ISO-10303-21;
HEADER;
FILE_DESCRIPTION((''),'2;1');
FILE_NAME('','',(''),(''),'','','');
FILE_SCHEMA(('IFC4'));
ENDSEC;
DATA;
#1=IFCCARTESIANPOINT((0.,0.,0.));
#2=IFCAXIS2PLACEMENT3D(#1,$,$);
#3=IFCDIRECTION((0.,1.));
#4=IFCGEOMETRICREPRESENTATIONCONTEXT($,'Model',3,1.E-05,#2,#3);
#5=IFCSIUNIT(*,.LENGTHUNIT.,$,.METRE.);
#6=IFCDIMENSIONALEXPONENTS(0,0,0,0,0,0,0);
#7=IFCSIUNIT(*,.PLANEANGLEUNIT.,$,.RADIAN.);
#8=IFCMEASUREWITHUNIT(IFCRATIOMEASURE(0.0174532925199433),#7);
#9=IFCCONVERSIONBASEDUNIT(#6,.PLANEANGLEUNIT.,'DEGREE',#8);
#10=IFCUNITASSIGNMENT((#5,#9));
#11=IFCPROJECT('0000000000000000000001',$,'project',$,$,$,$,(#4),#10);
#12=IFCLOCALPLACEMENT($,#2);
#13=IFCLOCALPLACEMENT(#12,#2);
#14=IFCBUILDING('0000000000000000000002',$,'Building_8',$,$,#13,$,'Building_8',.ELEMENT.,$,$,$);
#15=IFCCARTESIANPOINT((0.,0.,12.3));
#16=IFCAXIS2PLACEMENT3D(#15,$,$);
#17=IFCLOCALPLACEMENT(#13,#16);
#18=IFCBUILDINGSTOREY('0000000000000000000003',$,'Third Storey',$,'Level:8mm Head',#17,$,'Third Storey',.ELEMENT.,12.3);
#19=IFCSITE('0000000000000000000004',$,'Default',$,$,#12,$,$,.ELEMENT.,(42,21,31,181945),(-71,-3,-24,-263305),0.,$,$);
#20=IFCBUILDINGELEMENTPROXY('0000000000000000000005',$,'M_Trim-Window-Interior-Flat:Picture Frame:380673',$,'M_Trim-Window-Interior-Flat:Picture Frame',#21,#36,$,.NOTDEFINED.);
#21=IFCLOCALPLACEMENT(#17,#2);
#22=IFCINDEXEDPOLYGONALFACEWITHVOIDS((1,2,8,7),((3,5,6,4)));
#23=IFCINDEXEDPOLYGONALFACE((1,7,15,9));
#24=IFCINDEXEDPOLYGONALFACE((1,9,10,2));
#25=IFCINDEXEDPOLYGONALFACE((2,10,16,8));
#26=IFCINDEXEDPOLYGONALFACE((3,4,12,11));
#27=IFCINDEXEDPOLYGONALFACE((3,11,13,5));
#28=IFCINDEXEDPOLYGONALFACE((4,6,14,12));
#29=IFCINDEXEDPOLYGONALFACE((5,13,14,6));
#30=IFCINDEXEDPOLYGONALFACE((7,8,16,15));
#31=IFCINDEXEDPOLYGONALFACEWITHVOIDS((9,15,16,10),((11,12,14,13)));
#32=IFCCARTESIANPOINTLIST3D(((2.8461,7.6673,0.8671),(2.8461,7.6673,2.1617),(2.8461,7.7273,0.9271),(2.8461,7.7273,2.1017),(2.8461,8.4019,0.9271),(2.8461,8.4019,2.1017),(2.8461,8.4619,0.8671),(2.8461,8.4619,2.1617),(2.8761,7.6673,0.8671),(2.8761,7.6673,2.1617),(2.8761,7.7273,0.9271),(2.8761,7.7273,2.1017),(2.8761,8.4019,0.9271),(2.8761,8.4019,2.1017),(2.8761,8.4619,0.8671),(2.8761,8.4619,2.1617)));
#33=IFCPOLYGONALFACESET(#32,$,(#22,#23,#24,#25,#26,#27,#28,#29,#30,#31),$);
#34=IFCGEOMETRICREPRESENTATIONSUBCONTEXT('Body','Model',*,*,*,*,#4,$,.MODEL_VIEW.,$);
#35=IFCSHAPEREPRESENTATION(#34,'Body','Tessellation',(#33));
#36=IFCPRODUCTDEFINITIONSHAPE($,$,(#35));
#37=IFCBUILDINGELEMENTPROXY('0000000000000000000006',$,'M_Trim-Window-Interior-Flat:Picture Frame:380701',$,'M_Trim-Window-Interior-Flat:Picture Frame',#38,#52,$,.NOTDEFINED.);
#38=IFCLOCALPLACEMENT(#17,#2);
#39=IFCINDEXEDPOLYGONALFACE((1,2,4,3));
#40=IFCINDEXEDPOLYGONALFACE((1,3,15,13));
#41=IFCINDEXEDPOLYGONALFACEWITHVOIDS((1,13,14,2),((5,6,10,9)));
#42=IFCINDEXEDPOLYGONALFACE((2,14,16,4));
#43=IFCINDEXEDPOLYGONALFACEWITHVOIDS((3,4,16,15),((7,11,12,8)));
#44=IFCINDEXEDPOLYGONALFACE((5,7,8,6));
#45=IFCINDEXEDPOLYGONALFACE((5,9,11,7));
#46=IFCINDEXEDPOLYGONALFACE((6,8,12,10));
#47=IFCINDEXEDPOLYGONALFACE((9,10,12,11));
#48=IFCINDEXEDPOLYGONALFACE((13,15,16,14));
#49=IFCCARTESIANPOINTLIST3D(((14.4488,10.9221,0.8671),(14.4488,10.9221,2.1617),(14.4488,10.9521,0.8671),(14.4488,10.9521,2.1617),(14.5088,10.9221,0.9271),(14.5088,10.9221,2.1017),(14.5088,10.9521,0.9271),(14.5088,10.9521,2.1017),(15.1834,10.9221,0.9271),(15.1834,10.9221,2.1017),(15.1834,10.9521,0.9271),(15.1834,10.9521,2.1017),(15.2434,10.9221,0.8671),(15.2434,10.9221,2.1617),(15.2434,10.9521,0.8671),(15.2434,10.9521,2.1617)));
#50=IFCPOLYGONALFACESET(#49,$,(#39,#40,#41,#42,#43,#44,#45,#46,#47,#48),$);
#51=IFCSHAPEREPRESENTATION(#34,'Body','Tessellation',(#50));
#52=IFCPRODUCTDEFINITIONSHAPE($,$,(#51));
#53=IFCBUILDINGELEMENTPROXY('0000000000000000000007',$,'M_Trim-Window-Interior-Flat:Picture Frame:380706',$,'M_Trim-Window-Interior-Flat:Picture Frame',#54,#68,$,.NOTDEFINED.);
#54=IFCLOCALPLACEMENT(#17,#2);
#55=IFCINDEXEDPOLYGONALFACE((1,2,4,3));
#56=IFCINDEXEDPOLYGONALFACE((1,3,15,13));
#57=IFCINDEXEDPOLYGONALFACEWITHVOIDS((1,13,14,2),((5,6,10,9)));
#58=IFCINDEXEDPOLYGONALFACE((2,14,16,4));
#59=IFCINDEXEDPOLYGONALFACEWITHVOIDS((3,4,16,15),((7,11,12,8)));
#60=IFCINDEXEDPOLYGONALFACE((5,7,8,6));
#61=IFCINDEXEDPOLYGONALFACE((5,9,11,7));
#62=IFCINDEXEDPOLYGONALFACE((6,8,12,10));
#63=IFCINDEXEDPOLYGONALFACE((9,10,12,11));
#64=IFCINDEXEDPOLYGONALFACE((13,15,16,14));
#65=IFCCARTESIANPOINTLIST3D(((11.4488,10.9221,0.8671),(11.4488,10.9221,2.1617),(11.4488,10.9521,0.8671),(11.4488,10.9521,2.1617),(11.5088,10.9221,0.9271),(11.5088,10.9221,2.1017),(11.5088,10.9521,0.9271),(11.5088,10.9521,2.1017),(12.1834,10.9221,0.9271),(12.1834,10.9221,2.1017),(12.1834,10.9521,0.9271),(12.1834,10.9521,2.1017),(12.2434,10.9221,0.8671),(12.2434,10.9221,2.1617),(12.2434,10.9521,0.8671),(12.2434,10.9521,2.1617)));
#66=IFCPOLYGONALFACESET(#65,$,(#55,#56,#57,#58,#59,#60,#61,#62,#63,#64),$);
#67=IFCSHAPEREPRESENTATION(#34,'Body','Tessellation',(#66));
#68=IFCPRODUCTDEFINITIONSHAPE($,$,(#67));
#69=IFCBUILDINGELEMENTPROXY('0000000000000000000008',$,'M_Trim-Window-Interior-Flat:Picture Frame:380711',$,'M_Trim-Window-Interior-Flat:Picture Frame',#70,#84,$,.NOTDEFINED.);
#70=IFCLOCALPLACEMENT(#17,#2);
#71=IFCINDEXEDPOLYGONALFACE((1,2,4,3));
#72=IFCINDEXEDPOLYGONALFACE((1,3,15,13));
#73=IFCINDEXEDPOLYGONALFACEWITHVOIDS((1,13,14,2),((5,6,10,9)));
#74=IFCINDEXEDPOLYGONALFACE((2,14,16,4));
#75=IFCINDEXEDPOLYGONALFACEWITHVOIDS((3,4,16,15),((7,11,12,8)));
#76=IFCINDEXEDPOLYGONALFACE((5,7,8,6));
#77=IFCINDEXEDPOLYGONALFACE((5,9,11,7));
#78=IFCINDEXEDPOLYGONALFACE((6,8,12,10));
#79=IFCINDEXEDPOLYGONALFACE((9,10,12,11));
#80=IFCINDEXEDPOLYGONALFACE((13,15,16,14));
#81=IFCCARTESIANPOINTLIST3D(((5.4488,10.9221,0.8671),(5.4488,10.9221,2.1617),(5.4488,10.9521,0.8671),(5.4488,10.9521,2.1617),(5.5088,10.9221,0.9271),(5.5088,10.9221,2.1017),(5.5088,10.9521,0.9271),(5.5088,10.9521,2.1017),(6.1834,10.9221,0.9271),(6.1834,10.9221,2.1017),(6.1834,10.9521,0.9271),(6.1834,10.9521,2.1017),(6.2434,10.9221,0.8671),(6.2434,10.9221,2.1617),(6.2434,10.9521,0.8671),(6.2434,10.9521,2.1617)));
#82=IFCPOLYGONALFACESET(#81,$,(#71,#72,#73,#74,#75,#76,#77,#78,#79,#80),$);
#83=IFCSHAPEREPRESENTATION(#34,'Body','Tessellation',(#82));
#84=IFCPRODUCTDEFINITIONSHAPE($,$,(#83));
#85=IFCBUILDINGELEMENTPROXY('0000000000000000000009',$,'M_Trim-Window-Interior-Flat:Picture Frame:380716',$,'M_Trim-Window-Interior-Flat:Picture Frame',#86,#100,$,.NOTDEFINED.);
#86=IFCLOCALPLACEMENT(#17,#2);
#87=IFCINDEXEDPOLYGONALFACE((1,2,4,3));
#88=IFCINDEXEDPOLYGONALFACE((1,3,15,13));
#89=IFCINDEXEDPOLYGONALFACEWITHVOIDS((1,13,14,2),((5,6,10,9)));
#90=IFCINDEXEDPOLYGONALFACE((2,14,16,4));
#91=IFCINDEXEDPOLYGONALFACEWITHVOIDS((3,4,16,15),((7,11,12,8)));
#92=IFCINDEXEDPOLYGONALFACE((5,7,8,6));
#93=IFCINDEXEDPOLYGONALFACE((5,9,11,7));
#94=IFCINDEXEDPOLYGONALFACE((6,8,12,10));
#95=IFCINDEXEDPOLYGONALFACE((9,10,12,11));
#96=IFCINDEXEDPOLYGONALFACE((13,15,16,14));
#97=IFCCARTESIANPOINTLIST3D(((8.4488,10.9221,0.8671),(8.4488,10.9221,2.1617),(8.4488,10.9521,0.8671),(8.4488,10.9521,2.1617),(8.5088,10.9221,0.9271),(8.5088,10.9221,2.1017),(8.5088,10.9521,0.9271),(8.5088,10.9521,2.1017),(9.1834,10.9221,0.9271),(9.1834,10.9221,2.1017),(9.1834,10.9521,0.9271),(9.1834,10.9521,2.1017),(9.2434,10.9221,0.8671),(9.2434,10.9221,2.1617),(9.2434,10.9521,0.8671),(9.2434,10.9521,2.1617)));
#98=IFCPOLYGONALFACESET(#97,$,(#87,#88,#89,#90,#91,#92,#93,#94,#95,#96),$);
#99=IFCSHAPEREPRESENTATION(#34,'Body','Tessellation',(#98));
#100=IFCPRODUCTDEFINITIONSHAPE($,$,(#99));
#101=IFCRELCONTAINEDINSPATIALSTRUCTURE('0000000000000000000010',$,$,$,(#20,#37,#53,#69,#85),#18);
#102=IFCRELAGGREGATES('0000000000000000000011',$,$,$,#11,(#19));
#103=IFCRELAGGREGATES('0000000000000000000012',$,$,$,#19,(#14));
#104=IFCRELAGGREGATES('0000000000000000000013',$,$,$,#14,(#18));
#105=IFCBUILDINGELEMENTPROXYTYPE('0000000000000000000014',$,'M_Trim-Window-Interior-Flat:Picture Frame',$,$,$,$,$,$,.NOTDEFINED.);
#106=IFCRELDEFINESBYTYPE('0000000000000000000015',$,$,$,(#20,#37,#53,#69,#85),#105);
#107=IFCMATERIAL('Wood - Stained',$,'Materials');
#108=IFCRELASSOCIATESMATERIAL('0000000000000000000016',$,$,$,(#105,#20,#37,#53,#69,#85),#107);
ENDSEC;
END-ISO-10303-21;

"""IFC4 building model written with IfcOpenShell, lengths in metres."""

from ifc_helpers import new_model, entity, si_unit, converted_unit, direction, frame, origin, place, context, subcontext, project, spatial, indexed_curve, outline, extrude, source, transform, mapped, material, type_object, type_shapes, element, save


model = new_model("IFC4")

# Units and contexts
model_context = context("Model", 3, precision=1e-05, world=origin(), true_north=direction((0.0, 1.0)))
body_context = subcontext(model_context, "Body", "Model", "MODEL_VIEW")
ifc_project = project(units=[si_unit("LENGTHUNIT", "METRE"), converted_unit("PLANEANGLEUNIT", "DEGREE", entity("IfcRatioMeasure", 0.0174532925199433), si_unit("PLANEANGLEUNIT", "RADIAN"), dimensions=[0, 0, 0, 0, 0, 0, 0])], contexts=[model_context])

# Site, building, storey
site_placement = place(None, origin())
site = spatial("IfcSite", under=ifc_project, at=site_placement, Name="Default", CompositionType="ELEMENT", RefLatitude=(42, 21, 31, 181945), RefLongitude=(-71, -3, -24, -263305), RefElevation=0.0)
building_placement = place(site_placement, origin())
building = spatial("IfcBuilding", under=site, at=building_placement, Name="Building_8", LongName="Building_8", CompositionType="ELEMENT")
storey_placement = place(building_placement, frame((0.0, 0.0, 12.3)))
storey = spatial("IfcBuildingStorey", under=building, at=storey_placement, Name="Third Storey", ObjectType="Level:8mm Head", LongName="Third Storey", CompositionType="ELEMENT", Elevation=12.3)

# Shared definitions
ifc_material_1 = material(Name="Wood - Stained", Category="Materials")

# Building element proxies
building_element_proxy_type_1 = type_object("IfcBuildingElementProxyType", Name="M_Trim-Window-Interior-Flat:Picture Frame", PredefinedType="NOTDEFINED", material=ifc_material_1)
shared_shape_1 = source(origin(), body_context, "Body", "SweptSolid", [
    extrude(outline(indexed_curve([(-0.3973, -0.6473), (0.3973, -0.6473), (0.3973, 0.6473), (-0.3973, 0.6473), (-0.3973, -0.6473)], self_intersect=False), holes=[indexed_curve([(-0.3373, -0.5873), (-0.3373, 0.5873), (0.3373, 0.5873), (0.3373, -0.5873), (-0.3373, -0.5873)], self_intersect=False)]), frame((0.0, -0.6, 0.0), z_axis=(0.0, 0.0, 1.0), x_axis=(-1.0, 0.0, 0.0)), (0.0, 0.0, 1.0), 0.03),
])
type_shapes(building_element_proxy_type_1, [shared_shape_1])
for number, where, z_axis, x_axis, name in (
    (1, (2.8461, 8.0646, 2.1144), (1.0, 0.0, 0.0), (0.0, 1.0, 0.0), "M_Trim-Window-Interior-Flat:Picture Frame:380673"),
    (2, (14.8461, 10.9521, 2.1144), (0.0, -1.0, 0.0), (1.0, 0.0, 0.0), "M_Trim-Window-Interior-Flat:Picture Frame:380701"),
    (3, (11.8461, 10.9521, 2.1144), (0.0, -1.0, 0.0), (1.0, 0.0, 0.0), "M_Trim-Window-Interior-Flat:Picture Frame:380706"),
    (4, (5.8461, 10.9521, 2.1144), (0.0, -1.0, 0.0), (1.0, 0.0, 0.0), "M_Trim-Window-Interior-Flat:Picture Frame:380711"),
    (5, (8.8461, 10.9521, 2.1144), (0.0, -1.0, 0.0), (1.0, 0.0, 0.0), "M_Trim-Window-Interior-Flat:Picture Frame:380716"),
):
    element("IfcBuildingElementProxy", number, at=place(storey_placement, frame(where, z_axis=z_axis, x_axis=x_axis)), inside=storey, type_object=building_element_proxy_type_1, material=ifc_material_1, Name=name, ObjectType="M_Trim-Window-Interior-Flat:Picture Frame", PredefinedType="NOTDEFINED", context=body_context, shape_type="MappedRepresentation", body=[
        mapped(shared_shape_1, transform((0.0, 0.0, 0.0), scale=1.0)),
    ])

save(model, "model.ifc")
